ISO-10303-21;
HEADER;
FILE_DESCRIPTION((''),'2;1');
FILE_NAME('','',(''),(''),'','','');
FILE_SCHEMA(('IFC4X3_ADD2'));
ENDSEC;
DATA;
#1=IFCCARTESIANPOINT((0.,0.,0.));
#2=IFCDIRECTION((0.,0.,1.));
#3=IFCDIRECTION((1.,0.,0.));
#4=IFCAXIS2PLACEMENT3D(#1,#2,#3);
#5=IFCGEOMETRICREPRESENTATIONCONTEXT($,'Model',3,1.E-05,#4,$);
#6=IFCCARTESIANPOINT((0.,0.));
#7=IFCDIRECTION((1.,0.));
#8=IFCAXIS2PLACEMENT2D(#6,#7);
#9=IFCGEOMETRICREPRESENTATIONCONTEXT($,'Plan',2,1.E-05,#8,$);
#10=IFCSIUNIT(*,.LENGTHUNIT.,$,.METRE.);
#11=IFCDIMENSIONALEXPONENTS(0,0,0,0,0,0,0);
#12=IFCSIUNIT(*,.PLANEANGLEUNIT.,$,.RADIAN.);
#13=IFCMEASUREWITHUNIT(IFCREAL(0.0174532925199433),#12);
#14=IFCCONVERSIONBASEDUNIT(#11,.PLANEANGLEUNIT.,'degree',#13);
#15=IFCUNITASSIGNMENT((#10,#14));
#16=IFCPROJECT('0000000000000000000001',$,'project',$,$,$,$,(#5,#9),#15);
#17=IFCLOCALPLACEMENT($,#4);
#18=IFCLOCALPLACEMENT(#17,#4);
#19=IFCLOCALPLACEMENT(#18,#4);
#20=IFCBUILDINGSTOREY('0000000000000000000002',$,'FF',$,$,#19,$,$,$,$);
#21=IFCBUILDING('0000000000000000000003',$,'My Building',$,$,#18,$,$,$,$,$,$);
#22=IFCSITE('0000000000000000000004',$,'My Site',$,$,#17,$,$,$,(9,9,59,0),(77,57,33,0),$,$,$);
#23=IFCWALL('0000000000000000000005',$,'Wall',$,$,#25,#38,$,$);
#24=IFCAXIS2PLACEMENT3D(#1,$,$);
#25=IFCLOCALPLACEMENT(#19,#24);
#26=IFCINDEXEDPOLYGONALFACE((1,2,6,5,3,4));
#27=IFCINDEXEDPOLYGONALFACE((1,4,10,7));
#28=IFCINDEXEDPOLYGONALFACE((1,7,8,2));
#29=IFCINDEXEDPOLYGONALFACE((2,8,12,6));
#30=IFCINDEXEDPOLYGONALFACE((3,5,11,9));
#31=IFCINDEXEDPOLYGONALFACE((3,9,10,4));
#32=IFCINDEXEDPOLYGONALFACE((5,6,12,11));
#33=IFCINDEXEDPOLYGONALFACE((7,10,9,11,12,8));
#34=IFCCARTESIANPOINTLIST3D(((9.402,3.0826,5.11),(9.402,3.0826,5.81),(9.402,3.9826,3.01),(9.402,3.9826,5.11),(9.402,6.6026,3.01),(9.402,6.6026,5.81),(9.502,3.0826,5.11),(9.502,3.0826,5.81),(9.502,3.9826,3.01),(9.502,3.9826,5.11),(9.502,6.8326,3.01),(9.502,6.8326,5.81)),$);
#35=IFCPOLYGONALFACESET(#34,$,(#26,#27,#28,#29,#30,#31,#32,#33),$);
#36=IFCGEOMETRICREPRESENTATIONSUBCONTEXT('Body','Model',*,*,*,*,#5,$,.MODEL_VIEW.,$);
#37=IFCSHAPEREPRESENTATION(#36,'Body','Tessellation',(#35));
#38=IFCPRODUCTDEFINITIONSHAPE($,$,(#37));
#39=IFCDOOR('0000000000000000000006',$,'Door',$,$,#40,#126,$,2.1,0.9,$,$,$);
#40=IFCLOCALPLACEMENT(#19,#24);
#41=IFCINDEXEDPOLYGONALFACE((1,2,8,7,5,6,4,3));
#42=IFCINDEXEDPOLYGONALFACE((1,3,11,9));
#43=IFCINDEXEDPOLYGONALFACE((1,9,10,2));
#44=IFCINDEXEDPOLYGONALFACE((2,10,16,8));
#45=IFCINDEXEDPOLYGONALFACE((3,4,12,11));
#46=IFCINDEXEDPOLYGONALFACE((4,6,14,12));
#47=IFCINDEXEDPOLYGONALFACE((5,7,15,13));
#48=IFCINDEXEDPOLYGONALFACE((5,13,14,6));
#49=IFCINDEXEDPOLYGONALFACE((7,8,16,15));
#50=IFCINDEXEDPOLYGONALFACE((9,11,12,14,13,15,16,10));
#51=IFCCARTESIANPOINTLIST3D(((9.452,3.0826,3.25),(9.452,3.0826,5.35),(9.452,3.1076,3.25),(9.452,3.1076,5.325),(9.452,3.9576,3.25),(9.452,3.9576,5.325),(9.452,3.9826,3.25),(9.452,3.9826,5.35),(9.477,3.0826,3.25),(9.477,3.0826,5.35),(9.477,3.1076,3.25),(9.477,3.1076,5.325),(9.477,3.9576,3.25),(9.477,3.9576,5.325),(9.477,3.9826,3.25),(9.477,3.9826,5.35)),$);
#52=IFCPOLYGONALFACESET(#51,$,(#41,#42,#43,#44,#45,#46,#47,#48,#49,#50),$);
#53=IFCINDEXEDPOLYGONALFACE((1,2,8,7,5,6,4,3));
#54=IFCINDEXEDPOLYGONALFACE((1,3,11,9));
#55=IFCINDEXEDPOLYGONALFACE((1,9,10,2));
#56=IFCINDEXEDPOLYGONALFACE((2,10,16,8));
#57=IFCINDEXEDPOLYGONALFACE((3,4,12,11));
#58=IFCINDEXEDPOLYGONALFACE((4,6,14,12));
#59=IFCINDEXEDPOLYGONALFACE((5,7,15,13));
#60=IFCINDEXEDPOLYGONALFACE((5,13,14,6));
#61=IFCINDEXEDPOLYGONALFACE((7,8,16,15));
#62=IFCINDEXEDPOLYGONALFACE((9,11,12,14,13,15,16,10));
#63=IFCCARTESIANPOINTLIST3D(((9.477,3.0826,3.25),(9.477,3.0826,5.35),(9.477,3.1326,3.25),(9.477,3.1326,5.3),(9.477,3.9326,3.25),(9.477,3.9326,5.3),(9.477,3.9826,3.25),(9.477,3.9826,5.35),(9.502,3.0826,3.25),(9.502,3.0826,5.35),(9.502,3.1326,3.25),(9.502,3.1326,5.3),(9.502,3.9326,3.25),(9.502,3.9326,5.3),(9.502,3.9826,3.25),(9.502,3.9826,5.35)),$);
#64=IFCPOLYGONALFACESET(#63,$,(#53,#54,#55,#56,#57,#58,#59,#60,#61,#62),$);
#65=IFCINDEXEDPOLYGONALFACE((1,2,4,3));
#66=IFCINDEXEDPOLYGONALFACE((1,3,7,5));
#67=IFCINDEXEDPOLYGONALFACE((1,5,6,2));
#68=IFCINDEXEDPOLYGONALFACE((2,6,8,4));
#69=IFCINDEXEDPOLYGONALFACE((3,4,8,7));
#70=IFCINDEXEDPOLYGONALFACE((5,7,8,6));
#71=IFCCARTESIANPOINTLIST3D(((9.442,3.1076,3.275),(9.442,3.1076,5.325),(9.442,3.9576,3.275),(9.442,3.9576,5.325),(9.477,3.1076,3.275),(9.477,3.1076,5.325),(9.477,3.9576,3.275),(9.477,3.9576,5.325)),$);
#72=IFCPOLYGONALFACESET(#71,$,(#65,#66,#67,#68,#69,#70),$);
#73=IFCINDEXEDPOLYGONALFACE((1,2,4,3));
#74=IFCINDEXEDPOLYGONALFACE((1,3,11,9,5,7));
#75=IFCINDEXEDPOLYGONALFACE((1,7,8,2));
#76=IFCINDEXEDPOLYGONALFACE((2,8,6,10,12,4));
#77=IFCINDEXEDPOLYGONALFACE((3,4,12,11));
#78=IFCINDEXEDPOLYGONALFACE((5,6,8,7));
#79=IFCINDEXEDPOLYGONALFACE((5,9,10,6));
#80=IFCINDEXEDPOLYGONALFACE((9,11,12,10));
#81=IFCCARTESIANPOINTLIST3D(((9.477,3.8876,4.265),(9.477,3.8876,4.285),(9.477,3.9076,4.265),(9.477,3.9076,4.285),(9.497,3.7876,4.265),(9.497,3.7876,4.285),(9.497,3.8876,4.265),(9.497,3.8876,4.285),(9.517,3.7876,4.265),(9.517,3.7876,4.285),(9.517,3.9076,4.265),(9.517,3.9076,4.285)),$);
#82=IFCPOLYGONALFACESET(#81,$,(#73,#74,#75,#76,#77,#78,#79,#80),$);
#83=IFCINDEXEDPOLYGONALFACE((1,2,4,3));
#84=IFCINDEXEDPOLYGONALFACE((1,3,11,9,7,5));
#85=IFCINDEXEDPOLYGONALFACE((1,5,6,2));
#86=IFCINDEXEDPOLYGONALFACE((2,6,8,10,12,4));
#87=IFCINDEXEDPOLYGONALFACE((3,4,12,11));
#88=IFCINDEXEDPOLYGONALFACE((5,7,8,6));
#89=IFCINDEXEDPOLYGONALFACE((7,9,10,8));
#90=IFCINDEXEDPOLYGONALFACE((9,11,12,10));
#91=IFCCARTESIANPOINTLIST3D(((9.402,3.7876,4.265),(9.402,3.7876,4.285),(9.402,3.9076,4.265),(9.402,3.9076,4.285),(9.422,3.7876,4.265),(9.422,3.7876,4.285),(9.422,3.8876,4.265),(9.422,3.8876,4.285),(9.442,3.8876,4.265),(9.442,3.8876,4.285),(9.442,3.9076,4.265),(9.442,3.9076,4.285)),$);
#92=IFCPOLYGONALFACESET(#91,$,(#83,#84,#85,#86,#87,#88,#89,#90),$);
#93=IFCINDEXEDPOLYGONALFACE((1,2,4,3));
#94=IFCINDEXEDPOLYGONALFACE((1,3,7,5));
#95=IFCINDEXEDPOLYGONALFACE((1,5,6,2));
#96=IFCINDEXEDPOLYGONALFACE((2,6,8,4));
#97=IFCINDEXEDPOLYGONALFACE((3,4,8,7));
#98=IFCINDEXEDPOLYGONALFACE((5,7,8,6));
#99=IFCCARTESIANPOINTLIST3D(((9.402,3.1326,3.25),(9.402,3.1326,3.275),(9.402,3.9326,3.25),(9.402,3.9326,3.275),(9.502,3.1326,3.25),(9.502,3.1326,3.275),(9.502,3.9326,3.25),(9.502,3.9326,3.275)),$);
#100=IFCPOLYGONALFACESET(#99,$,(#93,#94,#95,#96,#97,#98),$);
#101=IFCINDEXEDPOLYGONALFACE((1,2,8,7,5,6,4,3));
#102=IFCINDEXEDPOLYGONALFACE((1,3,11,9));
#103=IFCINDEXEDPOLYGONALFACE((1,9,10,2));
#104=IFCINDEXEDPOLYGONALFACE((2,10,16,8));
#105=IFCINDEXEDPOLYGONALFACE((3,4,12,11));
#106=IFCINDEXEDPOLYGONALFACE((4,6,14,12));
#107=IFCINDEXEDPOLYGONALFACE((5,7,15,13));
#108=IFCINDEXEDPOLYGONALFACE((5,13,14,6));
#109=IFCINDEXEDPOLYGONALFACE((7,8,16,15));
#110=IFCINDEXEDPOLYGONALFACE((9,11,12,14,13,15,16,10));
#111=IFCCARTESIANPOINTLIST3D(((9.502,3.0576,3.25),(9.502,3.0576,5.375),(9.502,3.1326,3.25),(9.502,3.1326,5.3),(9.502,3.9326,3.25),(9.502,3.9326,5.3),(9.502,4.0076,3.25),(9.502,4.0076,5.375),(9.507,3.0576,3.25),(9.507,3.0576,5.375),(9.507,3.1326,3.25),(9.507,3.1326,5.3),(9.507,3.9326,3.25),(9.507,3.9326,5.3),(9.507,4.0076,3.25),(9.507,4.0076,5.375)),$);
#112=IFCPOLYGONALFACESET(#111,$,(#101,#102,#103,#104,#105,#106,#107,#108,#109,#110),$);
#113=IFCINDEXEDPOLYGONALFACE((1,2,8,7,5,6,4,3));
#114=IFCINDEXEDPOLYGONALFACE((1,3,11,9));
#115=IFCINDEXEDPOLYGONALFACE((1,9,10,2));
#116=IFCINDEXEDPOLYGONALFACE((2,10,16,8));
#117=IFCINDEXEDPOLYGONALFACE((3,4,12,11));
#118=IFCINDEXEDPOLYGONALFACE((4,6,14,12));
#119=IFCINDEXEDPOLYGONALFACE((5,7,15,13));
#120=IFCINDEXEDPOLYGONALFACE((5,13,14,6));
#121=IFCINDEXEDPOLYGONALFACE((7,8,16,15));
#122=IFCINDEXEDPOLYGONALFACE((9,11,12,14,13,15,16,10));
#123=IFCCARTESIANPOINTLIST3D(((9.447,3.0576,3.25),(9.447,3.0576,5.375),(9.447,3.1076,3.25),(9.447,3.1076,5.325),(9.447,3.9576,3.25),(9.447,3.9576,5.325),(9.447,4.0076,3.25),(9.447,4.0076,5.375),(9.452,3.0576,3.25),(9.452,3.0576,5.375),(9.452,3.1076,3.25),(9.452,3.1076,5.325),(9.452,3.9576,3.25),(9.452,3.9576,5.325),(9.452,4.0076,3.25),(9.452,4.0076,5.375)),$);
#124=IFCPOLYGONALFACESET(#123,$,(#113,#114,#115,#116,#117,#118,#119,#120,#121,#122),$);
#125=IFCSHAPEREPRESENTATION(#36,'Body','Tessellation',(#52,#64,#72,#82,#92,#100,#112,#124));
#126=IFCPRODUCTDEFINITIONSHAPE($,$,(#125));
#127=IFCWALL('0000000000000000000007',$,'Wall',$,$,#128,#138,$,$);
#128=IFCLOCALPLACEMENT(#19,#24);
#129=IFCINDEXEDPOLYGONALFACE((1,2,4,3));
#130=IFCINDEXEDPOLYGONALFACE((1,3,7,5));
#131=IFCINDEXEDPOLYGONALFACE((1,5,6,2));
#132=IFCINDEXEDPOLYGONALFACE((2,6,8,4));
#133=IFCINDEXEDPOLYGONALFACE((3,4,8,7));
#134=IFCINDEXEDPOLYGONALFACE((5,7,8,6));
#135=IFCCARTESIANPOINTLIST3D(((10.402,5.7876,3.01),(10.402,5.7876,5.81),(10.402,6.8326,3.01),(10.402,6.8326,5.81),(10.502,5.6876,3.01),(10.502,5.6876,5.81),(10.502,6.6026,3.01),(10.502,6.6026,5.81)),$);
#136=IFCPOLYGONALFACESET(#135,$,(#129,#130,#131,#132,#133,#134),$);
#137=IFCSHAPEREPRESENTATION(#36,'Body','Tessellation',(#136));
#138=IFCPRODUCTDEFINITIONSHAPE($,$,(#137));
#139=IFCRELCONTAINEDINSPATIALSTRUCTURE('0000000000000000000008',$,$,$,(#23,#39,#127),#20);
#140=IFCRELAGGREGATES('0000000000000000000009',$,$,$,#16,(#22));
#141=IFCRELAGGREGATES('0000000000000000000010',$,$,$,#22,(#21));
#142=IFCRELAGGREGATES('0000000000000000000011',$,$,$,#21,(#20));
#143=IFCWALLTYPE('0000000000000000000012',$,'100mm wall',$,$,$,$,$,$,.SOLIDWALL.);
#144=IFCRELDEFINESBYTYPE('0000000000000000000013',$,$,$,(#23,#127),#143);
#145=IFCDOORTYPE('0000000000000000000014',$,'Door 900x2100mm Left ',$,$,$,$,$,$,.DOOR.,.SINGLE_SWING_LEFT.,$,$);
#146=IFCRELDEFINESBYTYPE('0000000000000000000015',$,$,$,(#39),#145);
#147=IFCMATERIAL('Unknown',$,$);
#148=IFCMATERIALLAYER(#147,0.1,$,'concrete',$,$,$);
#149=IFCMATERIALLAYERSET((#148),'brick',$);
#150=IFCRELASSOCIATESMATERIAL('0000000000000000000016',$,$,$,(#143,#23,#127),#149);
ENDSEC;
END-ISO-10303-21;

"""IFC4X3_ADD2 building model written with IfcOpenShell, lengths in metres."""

from ifc_helpers import new_model, entity, si_unit, converted_unit, frame, origin_with_axes, origin_2d_with_axis, place, context, subcontext, project, spatial, line, indexed_curve, outline, extrude, shape, source, transform, mapped, material, layer, layer_set, layer_usage, type_object, type_shapes, element, fill, save


model = new_model("IFC4X3_ADD2")

# Units and contexts
model_context = context("Model", 3, precision=1e-05, world=origin_with_axes())
plan_context = context("Plan", 2, precision=1e-05, world=origin_2d_with_axis())
body_context_1 = subcontext(model_context, "Body", "Model", "MODEL_VIEW")
body_context_2 = subcontext(plan_context, "Body", "Plan", "PLAN_VIEW")
ifc_project = project(units=[si_unit("LENGTHUNIT", "METRE"), converted_unit("PLANEANGLEUNIT", "degree", entity("IfcReal", 0.0174532925199433), si_unit("PLANEANGLEUNIT", "RADIAN"), dimensions=[0, 0, 0, 0, 0, 0, 0])], contexts=[model_context, plan_context])

# Site, building, storey
site_placement = place(None, origin_with_axes())
site = spatial("IfcSite", under=ifc_project, at=site_placement, Name="My Site", RefLatitude=(9, 9, 59, 0), RefLongitude=(77, 57, 33, 0))
building_placement = place(site_placement, origin_with_axes())
building = spatial("IfcBuilding", under=site, at=building_placement, Name="My Building")
storey_placement = place(building_placement, origin_with_axes())
storey = spatial("IfcBuildingStorey", under=building, at=storey_placement, Name="FF")

# Shared definitions
ifc_material = material(Name="Unknown")

# Wall, opening, door
ifc_layer_1 = layer(ifc_material, 0.1, Name="concrete")
ifc_layer_set_1 = layer_set([ifc_layer_1], Name="brick")
ifc_layer_usage_1 = layer_usage(ifc_layer_set_1, "AXIS2", "POSITIVE", 0.0)
wall_type_1 = type_object("IfcWallType", Name="100mm wall", PredefinedType="SOLIDWALL", material=ifc_layer_set_1)
wall_1_placement = place(storey_placement, frame((9.502, 3.0826, 3.01), z_axis=(0.0, 0.0, 1.0), x_axis=(0.0, 1.0, 0.0)))
wall_1 = element("IfcWall", 1, at=wall_1_placement, inside=storey, type_object=wall_type_1, material=ifc_layer_usage_1, Name="Wall", context=body_context_1, shape_type="SweptSolid", body=[
    extrude(outline(indexed_curve([(0.0, 0.0), (0.0, 0.1), (3.52, 0.1), (3.75, 0.0)], segments=[line(1, 2, 3, 4, 1)])), origin_with_axes(), (0.0, 0.0, 1.0), 2.8),
])
shared_shape_1 = source(origin_with_axes(), body_context_1, "Body", "SweptSolid", [
    extrude(outline(indexed_curve([(0.0, 0.0), (0.9, 0.0), (0.9, 2.1), (0.0, 2.1)], segments=[line(1, 2, 3, 4, 1)])), frame((0.0, -0.6, 0.0), z_axis=(0.0, -1.0, 0.0), x_axis=(1.0, 0.0, 0.0)), (0.0, 0.0, -1.0), 1.2),
])
opening_1_placement = place(wall_1_placement, frame((0.0, 0.0, 0.0), z_axis=(0.0, 0.0, 1.0), x_axis=(1.0, 0.0, 0.0)))
opening_1 = element("IfcOpeningElement", 2, at=opening_1_placement, cuts=wall_1, PredefinedType="OPENING", context=body_context_1, shape_type="MappedRepresentation", body=[
    mapped(shared_shape_1, transform((0.0, 0.0, 0.0), x_axis=(1.0, 0.0, 0.0), y_axis=(0.0, 1.0, 0.0), z_axis=(0.0, 0.0, 1.0), scale=1.0)),
])
door_type_1 = type_object("IfcDoorType", Name="Door 900x2100mm Left ", OperationType="SINGLE_SWING_LEFT", PredefinedType="DOOR")
shared_shape_2 = source(origin_with_axes(), body_context_1, "Body", "SweptSolid", [
    extrude(outline(indexed_curve([(0.0, 0.0), (0.0, 2.1), (0.9, 2.1), (0.9, 0.0), (0.875, 0.0), (0.875, 2.075), (0.025, 2.075), (0.025, 0.0)], segments=[line(1, 2, 3, 4, 5, 6, 7, 8, 1)])), frame((0.0, 0.025, 0.0), z_axis=(0.0, -1.0, 0.0), x_axis=(1.0, 0.0, 0.0)), (0.0, 0.0, -1.0), 0.025),
    extrude(outline(indexed_curve([(0.0, 0.0), (0.0, 2.1), (0.9, 2.1), (0.9, 0.0), (0.85, 0.0), (0.85, 2.05), (0.05, 2.05), (0.05, 0.0)], segments=[line(1, 2, 3, 4, 5, 6, 7, 8, 1)])), frame((0.0, 0.0, 0.0), z_axis=(0.0, -1.0, 0.0), x_axis=(1.0, 0.0, 0.0)), (0.0, 0.0, -1.0), 0.025),
    extrude(outline(indexed_curve([(0.0, 0.0), (0.85, 0.0), (0.85, 0.035), (0.0, 0.035)], segments=[line(1, 2, 3, 4, 1)])), frame((0.025, 0.025, 0.025), z_axis=(0.0, 0.0, 1.0), x_axis=(1.0, 0.0, 0.0)), (0.0, 0.0, 1.0), 2.05),
    extrude(outline(indexed_curve([(0.0, 0.0), (0.0, -0.04), (-0.12, -0.04), (-0.12, -0.02), (-0.02, -0.02), (-0.02, 0.0)], segments=[line(1, 2, 3, 4, 5, 6, 1)])), frame((0.825, 0.025, 1.015), z_axis=(0.0, 0.0, 1.0), x_axis=(1.0, 0.0, 0.0)), (0.0, 0.0, 1.0), 0.02),
    extrude(outline(indexed_curve([(0.0, 0.0), (0.0, 0.04), (-0.12, 0.04), (-0.12, 0.02), (-0.02, 0.02), (-0.02, 0.0)], segments=[line(1, 2, 3, 4, 5, 6, 1)])), frame((0.825, 0.06, 1.015), z_axis=(0.0, 0.0, 1.0), x_axis=(1.0, 0.0, 0.0)), (0.0, 0.0, 1.0), 0.02),
    extrude(outline(indexed_curve([(0.0, 0.0), (0.8, 0.0), (0.8, 0.1), (0.0, 0.1)], segments=[line(1, 2, 3, 4, 1)])), frame((0.05, 0.0, 0.0), z_axis=(0.0, 0.0, 1.0), x_axis=(1.0, 0.0, 0.0)), (0.0, 0.0, 1.0), 0.025),
    extrude(outline(indexed_curve([(0.0, 0.0), (0.0, 2.125), (0.95, 2.125), (0.95, 0.0), (0.875, 0.0), (0.875, 2.05), (0.075, 2.05), (0.075, 0.0)], segments=[line(1, 2, 3, 4, 5, 6, 7, 8, 1)])), frame((-0.025, -0.005, 0.0), z_axis=(0.0, -1.0, 0.0), x_axis=(1.0, 0.0, 0.0)), (0.0, 0.0, -1.0), 0.005),
    extrude(outline(indexed_curve([(0.0, 0.0), (0.0, 2.125), (0.95, 2.125), (0.95, 0.0), (0.9, 0.0), (0.9, 2.075), (0.05, 2.075), (0.05, 0.0)], segments=[line(1, 2, 3, 4, 5, 6, 7, 8, 1)])), frame((-0.025, 0.05, 0.0), z_axis=(0.0, -1.0, 0.0), x_axis=(1.0, 0.0, 0.0)), (0.0, 0.0, -1.0), 0.005),
])
shared_shape_3 = source(origin_with_axes(), body_context_2, "Body", "Curve2D", [
    entity("IfcIndexedPolyCurve", entity("IfcCartesianPointList2D", [[0.0, 0.0], [0.0, 0.05], [0.025, 0.05], [0.025, 0.025], [0.05, 0.025], [0.05, 0.0]]), [entity("IfcLineIndex", [1, 2, 3, 4, 5, 6, 1])]),
    entity("IfcIndexedPolyCurve", entity("IfcCartesianPointList2D", [[0.9, 0.0], [0.9, 0.05], [0.875, 0.05], [0.875, 0.025], [0.85, 0.025], [0.85, 0.0]]), [entity("IfcLineIndex", [1, 2, 3, 4, 5, 6, 1])]),
    entity("IfcTrimmedCurve", entity("IfcEllipse", entity("IfcAxis2Placement2D", entity("IfcCartesianPoint", [0.06, 0.05]), entity("IfcDirection", [1.0, 0.0])), 0.815, 0.85), [entity("IfcCartesianPoint", [0.875, 0.05])], [entity("IfcCartesianPoint", [0.06, 0.9])], True, "CARTESIAN"),
    entity("IfcIndexedPolyCurve", entity("IfcCartesianPointList2D", [[0.025, 0.05], [0.06, 0.05], [0.06, 0.9], [0.025, 0.9]]), [entity("IfcLineIndex", [1, 2, 3, 4, 1])]),
])
type_shapes(door_type_1, [shared_shape_2, shared_shape_3])
door_1_placement = place(opening_1_placement, frame((0.0, 0.0, 0.24), z_axis=(0.0, 0.0, 1.0), x_axis=(1.0, 0.0, 0.0)))
door_1 = element("IfcDoor", 3, at=door_1_placement, inside=storey, type_object=door_type_1, Name="Door", OverallHeight=2.1, OverallWidth=0.9, shapes=[
    shape(body_context_1, "Body", "MappedRepresentation", [mapped(shared_shape_2, transform((0.0, 0.0, 0.0), x_axis=(1.0, 0.0, 0.0), y_axis=(0.0, 1.0, 0.0), z_axis=(0.0, 0.0, 1.0), scale=1.0))]),
    shape(body_context_2, "Body", "MappedRepresentation", [mapped(shared_shape_3, transform((0.0, 0.0, 0.0), x_axis=(1.0, 0.0, 0.0), y_axis=(0.0, 1.0, 0.0), z_axis=(0.0, 0.0, 1.0), scale=1.0))]),
])
fill(opening_1, door_1)

# Wall
ifc_layer_usage_2 = layer_usage(ifc_layer_set_1, "AXIS2", "POSITIVE", 0.0)
wall_2_placement = place(storey_placement, frame((10.502, 5.7876, 3.01), z_axis=(0.0, 0.0, 1.0), x_axis=(0.0, 1.0, 0.0)))
element("IfcWall", 4, at=wall_2_placement, inside=storey, type_object=wall_type_1, material=ifc_layer_usage_2, Name="Wall", context=body_context_1, shape_type="SweptSolid", body=[
    extrude(outline(indexed_curve([(-0.1, 0.0), (0.0, 0.1), (1.045, 0.1), (0.815, 0.0)], segments=[line(1, 2, 3, 4, 1)])), origin_with_axes(), (0.0, 0.0, 1.0), 2.8),
])

save(model, "model.ifc")
